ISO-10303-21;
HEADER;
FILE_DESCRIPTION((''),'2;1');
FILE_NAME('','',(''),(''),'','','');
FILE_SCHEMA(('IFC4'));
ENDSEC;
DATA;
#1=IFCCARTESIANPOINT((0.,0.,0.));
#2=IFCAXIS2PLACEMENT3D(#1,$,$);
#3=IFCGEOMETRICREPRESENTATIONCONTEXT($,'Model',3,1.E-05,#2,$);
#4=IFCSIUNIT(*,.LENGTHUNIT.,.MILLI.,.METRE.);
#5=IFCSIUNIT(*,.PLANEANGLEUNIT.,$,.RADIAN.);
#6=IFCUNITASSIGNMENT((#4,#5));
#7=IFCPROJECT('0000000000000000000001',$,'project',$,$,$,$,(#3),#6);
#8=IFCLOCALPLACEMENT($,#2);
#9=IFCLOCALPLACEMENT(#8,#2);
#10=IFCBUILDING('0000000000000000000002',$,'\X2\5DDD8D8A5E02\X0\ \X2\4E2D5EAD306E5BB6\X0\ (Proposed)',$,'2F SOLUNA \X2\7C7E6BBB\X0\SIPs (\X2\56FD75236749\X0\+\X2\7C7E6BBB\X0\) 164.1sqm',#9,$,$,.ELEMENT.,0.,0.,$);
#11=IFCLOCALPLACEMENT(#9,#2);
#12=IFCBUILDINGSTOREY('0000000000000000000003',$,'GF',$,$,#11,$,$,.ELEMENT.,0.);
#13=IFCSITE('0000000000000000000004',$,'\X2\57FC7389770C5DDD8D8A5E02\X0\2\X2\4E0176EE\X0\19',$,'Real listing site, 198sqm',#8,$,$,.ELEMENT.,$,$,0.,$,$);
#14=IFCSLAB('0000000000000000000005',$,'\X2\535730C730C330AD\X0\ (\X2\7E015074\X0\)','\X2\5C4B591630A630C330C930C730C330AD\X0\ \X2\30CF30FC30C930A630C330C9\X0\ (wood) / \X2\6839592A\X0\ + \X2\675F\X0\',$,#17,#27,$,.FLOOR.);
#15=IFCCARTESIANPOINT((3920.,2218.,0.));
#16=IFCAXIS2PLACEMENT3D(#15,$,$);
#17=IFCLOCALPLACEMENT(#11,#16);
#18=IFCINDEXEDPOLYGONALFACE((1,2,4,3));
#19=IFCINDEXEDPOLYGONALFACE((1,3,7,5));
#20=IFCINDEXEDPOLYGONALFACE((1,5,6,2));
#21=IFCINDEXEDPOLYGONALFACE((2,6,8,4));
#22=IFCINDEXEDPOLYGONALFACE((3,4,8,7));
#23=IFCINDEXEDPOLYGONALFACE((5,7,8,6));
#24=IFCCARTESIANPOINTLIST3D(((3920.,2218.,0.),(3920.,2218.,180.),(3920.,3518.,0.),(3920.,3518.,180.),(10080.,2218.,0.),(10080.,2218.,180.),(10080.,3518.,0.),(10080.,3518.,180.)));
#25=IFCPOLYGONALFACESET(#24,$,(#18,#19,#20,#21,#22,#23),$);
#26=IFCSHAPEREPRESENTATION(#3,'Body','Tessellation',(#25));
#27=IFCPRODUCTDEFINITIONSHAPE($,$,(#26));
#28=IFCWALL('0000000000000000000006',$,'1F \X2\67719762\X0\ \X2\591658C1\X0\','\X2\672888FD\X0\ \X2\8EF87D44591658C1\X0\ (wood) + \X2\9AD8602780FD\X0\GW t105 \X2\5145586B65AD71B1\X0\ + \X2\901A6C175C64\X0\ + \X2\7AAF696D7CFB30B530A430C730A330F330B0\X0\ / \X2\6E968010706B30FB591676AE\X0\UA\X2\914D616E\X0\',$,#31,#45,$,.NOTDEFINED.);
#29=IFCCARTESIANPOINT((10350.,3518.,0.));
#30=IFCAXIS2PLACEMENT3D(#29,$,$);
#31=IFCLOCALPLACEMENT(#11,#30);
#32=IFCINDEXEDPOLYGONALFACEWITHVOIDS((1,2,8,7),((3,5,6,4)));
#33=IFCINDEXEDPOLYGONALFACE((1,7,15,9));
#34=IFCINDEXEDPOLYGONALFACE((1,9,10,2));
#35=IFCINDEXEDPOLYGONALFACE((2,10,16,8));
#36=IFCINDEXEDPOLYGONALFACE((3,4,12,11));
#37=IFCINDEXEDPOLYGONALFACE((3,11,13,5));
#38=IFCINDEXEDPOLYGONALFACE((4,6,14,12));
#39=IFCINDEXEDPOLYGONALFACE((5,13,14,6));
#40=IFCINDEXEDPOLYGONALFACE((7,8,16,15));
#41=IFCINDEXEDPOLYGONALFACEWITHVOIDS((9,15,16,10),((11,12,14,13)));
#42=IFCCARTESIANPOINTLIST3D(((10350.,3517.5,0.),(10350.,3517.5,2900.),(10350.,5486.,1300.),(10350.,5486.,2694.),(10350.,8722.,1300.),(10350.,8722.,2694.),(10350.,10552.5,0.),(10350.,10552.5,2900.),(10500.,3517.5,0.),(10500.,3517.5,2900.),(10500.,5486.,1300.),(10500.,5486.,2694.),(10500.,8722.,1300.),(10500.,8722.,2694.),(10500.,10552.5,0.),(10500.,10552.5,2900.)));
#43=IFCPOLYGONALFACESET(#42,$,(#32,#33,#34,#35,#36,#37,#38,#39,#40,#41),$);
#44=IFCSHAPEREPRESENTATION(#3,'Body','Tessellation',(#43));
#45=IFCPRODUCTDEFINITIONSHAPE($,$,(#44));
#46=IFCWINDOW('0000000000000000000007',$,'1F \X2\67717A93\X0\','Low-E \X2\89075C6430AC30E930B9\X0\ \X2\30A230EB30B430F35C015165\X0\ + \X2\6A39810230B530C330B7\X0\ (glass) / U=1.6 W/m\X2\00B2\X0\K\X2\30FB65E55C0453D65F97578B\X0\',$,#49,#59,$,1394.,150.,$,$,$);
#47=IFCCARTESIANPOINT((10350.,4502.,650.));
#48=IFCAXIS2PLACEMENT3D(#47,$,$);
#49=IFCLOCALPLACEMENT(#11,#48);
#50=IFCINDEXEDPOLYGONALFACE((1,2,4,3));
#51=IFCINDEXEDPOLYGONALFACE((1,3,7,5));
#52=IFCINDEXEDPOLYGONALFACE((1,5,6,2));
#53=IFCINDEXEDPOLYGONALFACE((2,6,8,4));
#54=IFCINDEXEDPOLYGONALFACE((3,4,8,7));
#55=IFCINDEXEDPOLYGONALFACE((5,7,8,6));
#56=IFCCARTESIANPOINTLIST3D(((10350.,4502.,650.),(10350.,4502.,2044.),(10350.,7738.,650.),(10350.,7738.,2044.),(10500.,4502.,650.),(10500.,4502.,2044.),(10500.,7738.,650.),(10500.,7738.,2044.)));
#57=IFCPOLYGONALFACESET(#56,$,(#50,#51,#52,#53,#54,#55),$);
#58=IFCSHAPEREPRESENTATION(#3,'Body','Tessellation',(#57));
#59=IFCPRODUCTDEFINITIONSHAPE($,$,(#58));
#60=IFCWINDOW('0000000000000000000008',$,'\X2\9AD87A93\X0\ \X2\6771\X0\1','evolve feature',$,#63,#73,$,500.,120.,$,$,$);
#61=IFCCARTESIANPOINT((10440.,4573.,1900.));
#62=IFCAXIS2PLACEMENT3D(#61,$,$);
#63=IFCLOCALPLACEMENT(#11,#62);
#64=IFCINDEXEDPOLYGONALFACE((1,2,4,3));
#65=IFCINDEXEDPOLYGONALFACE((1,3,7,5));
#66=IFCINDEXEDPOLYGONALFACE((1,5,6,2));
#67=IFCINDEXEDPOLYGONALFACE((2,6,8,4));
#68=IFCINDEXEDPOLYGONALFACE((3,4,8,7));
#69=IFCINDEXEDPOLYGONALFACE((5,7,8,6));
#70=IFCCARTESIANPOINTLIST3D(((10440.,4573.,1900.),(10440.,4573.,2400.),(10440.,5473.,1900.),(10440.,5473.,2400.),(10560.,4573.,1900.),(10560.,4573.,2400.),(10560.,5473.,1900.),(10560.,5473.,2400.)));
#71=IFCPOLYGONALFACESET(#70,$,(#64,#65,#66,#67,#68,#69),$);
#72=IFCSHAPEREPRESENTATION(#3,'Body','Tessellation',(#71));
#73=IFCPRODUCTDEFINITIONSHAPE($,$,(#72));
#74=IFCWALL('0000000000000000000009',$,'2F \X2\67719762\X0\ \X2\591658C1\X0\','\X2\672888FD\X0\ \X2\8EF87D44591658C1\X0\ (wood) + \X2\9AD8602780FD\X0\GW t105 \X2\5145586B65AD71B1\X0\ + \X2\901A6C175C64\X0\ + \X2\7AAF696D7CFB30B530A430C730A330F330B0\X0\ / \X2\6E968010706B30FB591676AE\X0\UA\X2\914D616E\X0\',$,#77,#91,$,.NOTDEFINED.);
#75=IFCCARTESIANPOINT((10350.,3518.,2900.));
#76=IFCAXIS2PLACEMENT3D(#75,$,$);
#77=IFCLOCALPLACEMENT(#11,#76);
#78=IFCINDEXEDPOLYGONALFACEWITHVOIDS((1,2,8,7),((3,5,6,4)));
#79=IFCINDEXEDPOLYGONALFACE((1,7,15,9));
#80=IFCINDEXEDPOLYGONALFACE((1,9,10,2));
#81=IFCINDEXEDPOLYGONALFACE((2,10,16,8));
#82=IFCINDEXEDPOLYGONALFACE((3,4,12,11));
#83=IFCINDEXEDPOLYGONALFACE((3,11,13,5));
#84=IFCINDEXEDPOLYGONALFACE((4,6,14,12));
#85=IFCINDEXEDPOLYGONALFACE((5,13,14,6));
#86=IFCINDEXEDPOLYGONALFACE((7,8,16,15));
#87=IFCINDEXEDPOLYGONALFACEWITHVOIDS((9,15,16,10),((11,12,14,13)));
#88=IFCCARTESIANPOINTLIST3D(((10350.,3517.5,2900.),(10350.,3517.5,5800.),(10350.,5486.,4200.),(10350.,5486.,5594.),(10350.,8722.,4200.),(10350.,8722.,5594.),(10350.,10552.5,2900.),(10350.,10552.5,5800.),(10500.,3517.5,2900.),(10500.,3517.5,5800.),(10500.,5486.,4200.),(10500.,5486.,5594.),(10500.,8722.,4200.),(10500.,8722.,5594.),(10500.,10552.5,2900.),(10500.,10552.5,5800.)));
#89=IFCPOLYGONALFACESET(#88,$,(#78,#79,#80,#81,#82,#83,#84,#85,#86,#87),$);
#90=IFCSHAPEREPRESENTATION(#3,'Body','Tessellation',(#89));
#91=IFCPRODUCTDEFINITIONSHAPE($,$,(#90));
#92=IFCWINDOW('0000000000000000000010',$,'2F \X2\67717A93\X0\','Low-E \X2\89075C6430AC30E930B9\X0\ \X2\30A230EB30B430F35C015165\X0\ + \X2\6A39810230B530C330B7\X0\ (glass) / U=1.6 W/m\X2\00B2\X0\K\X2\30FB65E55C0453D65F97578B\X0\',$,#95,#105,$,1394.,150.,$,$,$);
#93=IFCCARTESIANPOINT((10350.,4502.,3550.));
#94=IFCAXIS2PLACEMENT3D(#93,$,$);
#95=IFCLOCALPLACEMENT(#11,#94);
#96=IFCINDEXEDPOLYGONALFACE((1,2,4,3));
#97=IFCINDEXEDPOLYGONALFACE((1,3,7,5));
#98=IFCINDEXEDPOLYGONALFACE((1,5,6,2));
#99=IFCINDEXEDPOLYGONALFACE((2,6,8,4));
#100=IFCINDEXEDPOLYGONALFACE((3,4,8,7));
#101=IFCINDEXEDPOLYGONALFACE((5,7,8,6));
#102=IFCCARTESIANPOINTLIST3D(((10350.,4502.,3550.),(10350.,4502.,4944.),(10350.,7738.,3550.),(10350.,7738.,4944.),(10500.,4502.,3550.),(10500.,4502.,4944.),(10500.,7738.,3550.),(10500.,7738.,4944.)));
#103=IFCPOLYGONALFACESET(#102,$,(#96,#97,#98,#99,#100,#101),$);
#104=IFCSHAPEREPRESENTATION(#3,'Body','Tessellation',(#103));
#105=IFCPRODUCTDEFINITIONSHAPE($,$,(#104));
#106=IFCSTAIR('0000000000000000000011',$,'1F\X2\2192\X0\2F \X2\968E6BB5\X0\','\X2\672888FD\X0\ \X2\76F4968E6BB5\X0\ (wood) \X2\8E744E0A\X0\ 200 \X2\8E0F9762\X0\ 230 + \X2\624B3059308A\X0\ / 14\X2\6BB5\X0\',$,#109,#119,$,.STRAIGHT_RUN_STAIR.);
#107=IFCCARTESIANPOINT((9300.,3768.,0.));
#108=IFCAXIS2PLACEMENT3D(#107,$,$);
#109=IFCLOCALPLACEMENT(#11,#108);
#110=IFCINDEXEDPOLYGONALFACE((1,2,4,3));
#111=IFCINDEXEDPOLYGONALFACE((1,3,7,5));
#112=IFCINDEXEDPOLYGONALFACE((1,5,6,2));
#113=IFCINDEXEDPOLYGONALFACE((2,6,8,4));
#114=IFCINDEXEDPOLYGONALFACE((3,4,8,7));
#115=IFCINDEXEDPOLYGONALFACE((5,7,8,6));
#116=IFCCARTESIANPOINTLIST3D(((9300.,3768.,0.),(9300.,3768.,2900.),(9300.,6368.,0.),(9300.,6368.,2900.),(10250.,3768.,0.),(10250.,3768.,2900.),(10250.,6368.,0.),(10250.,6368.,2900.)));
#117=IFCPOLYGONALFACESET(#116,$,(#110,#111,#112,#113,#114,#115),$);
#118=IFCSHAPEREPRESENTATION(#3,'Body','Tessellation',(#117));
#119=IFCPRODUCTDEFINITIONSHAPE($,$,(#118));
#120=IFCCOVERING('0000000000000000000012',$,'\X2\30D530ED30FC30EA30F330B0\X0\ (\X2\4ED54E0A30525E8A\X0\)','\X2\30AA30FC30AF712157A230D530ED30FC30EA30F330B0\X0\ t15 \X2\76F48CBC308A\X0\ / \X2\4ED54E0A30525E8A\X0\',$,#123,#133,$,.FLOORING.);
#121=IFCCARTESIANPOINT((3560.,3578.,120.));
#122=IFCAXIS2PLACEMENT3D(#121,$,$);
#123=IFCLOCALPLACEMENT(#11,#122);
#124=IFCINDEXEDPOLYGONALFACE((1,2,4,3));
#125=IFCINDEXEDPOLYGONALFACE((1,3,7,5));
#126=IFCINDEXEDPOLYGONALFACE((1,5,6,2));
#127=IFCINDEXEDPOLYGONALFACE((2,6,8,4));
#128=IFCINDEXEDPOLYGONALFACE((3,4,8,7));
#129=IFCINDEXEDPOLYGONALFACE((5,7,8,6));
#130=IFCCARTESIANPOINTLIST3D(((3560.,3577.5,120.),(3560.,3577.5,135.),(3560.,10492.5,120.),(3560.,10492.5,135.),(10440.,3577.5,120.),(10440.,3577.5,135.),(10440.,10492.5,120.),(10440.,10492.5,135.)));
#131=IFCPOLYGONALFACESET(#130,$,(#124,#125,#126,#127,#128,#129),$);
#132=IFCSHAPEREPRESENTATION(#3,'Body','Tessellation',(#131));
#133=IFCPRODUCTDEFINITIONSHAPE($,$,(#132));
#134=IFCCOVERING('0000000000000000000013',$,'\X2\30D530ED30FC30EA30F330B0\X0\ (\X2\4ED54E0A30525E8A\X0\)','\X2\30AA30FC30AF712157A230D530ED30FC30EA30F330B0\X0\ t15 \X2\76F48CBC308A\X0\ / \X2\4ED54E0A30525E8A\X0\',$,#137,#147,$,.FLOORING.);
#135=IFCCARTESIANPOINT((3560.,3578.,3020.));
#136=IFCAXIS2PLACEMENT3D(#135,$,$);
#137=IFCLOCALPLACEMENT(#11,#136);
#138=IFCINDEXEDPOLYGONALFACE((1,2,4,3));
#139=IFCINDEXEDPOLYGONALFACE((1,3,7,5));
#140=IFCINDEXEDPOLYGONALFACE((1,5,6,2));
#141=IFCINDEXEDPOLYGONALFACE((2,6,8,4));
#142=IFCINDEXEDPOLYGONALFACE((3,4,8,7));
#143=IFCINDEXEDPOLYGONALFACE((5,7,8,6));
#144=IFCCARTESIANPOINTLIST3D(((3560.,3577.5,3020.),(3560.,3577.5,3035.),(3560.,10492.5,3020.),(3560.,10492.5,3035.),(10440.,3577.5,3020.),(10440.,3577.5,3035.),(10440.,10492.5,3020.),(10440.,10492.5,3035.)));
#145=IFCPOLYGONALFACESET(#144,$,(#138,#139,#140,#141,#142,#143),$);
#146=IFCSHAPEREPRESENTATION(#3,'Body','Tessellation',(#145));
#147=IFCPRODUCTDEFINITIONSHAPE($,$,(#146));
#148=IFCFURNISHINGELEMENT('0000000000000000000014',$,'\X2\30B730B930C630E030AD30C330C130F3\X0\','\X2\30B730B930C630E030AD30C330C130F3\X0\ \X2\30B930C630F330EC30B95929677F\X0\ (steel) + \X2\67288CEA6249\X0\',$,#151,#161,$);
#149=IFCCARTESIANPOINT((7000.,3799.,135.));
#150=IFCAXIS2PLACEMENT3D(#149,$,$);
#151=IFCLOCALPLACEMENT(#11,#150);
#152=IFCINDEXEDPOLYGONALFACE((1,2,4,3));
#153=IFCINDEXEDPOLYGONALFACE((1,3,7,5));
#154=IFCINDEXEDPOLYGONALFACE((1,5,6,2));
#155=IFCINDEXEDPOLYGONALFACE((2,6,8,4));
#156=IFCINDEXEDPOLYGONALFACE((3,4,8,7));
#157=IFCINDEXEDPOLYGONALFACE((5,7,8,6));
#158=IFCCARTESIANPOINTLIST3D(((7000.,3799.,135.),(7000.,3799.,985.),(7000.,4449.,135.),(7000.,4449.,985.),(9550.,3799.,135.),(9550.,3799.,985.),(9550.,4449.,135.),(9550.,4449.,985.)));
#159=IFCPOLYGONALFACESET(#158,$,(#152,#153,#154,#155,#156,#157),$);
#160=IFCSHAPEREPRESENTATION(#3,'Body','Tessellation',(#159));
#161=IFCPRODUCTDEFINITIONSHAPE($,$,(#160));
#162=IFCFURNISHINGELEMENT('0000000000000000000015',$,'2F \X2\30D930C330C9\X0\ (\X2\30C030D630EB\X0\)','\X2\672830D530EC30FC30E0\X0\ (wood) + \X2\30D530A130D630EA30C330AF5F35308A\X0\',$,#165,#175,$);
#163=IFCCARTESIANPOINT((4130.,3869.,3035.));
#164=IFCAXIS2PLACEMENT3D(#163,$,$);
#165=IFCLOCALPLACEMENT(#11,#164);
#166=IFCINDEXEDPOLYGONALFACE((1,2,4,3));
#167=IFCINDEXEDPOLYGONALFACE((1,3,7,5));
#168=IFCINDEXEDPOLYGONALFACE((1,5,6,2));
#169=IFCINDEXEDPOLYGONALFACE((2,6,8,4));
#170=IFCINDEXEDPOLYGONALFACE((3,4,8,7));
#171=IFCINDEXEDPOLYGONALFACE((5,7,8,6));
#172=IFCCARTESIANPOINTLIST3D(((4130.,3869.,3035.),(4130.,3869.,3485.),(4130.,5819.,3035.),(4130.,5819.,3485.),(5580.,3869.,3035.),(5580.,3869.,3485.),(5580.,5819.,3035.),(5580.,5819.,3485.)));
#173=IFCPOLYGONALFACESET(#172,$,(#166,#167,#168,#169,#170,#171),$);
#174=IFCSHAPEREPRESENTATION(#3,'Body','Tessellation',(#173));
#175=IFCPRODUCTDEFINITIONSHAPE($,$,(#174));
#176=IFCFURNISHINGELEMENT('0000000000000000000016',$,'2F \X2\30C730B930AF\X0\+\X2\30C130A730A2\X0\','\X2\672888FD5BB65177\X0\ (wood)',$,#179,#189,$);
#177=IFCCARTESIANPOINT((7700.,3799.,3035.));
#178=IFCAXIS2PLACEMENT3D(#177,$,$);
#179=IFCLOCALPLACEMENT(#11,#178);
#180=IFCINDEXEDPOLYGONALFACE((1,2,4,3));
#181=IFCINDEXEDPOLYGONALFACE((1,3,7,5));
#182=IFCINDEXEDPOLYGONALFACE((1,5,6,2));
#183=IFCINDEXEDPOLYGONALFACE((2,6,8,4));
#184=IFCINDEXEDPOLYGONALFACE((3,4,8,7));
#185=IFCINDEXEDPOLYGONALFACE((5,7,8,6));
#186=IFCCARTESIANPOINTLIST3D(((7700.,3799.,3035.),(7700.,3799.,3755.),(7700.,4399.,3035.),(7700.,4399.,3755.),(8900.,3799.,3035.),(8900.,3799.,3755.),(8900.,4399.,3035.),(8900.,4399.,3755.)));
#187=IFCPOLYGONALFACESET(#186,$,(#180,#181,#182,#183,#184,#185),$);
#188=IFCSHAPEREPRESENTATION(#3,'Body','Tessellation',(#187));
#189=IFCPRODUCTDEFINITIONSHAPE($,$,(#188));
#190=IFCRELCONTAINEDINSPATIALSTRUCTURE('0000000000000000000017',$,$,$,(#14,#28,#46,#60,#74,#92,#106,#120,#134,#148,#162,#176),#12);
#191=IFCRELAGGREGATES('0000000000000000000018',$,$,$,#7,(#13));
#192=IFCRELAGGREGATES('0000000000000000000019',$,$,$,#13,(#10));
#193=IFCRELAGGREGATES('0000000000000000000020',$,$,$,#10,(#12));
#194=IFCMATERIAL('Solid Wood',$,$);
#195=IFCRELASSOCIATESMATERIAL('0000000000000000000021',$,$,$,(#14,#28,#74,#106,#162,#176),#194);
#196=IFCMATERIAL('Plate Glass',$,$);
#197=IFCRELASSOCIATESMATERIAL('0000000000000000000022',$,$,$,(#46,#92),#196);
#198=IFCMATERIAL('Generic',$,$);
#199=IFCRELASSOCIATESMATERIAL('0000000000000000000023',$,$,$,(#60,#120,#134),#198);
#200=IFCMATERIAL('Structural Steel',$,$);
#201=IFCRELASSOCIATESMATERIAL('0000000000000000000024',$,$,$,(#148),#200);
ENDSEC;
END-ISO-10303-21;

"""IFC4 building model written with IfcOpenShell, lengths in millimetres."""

from ifc_helpers import new_model, si_unit, frame, frame_2d, origin, place, context, project, spatial, rectangle, extrude, material, element, fill, save


model = new_model("IFC4")

# Units and contexts
model_context = context("Model", 3, precision=1e-05, world=origin())
ifc_project = project(units=[si_unit("LENGTHUNIT", "METRE", prefix="MILLI"), si_unit("PLANEANGLEUNIT", "RADIAN")], contexts=[model_context])

# Site, building, storey
site_placement = place(None, origin())
site = spatial("IfcSite", under=ifc_project, at=site_placement, Name="埼玉県川越市2丁目19", ObjectType="Real listing site, 198sqm", CompositionType="ELEMENT", RefElevation=0.0)
building_placement = place(site_placement, origin())
building = spatial("IfcBuilding", under=site, at=building_placement, Name="川越市 中庭の家 (Proposed)", ObjectType="2F SOLUNA 籾殻SIPs (国産杉+籾殻) 164.1sqm", CompositionType="ELEMENT", ElevationOfRefHeight=0.0, ElevationOfTerrain=0.0)
storey_placement = place(building_placement, origin())
storey = spatial("IfcBuildingStorey", under=building, at=storey_placement, Name="GF", CompositionType="ELEMENT", Elevation=0.0)

# Slab
ifc_material_1 = material(Name="Solid Wood")
slab_placement = place(storey_placement, frame((3920.0, 2218.0, 0.0)))
element("IfcSlab", 1, at=slab_placement, inside=storey, material=ifc_material_1, Name="南デッキ (縁側)", Description="屋外ウッドデッキ ハードウッド (wood) / 根太 + 束", PredefinedType="FLOOR", context=model_context, shape_type="SweptSolid", body=[
    extrude(rectangle(XDim=6160.0, YDim=1300.0, at=frame_2d((3080.0, 650.0))), frame((3920.0, 2218.0, 0.0)), (0.0, 0.0, 1.0), 180.0),
])

# Wall, openings, windows
wall_1_placement = place(storey_placement, frame((10350.0, 3518.0, 0.0)))
wall_1 = element("IfcWall", 2, at=wall_1_placement, inside=storey, material=ifc_material_1, Name="1F 東面 外壁", Description="木製 軸組外壁 (wood) + 高性能GW t105 充填断熱 + 通気層 + 窯業系サイディング / 準耐火・外皮UA配慮", PredefinedType="NOTDEFINED", context=model_context, shape_type="SweptSolid", body=[
    extrude(rectangle(XDim=150.0, YDim=7035.0, at=frame_2d((75.0, 3517.0))), frame((10350.0, 3518.0, 0.0)), (0.0, 0.0, 1.0), 2900.0),
])
opening_1_placement = place(storey_placement, frame((10350.0, 4502.0, 650.0)))
opening_1 = element("IfcOpeningElement", 3, at=opening_1_placement, cuts=wall_1, PredefinedType="NOTDEFINED", context=model_context, shape_type="SweptSolid", body=[
    extrude(rectangle(XDim=150.0, YDim=3236.0, at=frame_2d((75.0, 1618.0))), frame((10350.0, 4502.0, 650.0)), (0.0, 0.0, 1.0), 1394.0),
])
opening_2_placement = place(storey_placement, frame((10440.0, 4573.0, 1900.0)))
opening_2 = element("IfcOpeningElement", 4, at=opening_2_placement, cuts=wall_1, PredefinedType="NOTDEFINED", context=model_context, shape_type="SweptSolid", body=[
    extrude(rectangle(XDim=120.0, YDim=900.0, at=frame_2d((60.0, 450.0))), frame((10440.0, 4573.0, 1900.0)), (0.0, 0.0, 1.0), 500.0),
])
ifc_material_2 = material(Name="Plate Glass")
window_1_placement = place(storey_placement, frame((10350.0, 4502.0, 650.0)))
window_1 = element("IfcWindow", 5, at=window_1_placement, inside=storey, material=ifc_material_2, Name="1F 東窓", Description="Low-E 複層ガラス アルゴン封入 + 樹脂サッシ (glass) / U=1.6 W/m²K・日射取得型", OverallHeight=1394.0, OverallWidth=150.0, context=model_context, shape_type="SweptSolid", body=[
    extrude(rectangle(XDim=150.0, YDim=3236.0, at=frame_2d((75.0, 1618.0))), frame((10350.0, 4502.0, 650.0)), (0.0, 0.0, 1.0), 1394.0),
])
fill(opening_1, window_1)
ifc_material_3 = material(Name="Generic")
window_2_placement = place(storey_placement, frame((10440.0, 4573.0, 1900.0)))
window_2 = element("IfcWindow", 6, at=window_2_placement, inside=storey, material=ifc_material_3, Name="高窓 東1", Description="evolve feature", OverallHeight=500.0, OverallWidth=120.0, context=model_context, shape_type="SweptSolid", body=[
    extrude(rectangle(XDim=120.0, YDim=900.0, at=frame_2d((60.0, 450.0))), frame((10440.0, 4573.0, 1900.0)), (0.0, 0.0, 1.0), 500.0),
])
fill(opening_2, window_2)

# Wall, opening, window
wall_2_placement = place(storey_placement, frame((10350.0, 3518.0, 2900.0)))
wall_2 = element("IfcWall", 7, at=wall_2_placement, inside=storey, material=ifc_material_1, Name="2F 東面 外壁", Description="木製 軸組外壁 (wood) + 高性能GW t105 充填断熱 + 通気層 + 窯業系サイディング / 準耐火・外皮UA配慮", PredefinedType="NOTDEFINED", context=model_context, shape_type="SweptSolid", body=[
    extrude(rectangle(XDim=150.0, YDim=7035.0, at=frame_2d((75.0, 3517.0))), frame((10350.0, 3518.0, 2900.0)), (0.0, 0.0, 1.0), 2900.0),
])
opening_3_placement = place(storey_placement, frame((10350.0, 4502.0, 3550.0)))
opening_3 = element("IfcOpeningElement", 8, at=opening_3_placement, cuts=wall_2, PredefinedType="NOTDEFINED", context=model_context, shape_type="SweptSolid", body=[
    extrude(rectangle(XDim=150.0, YDim=3236.0, at=frame_2d((75.0, 1618.0))), frame((10350.0, 4502.0, 3550.0)), (0.0, 0.0, 1.0), 1394.0),
])
window_3_placement = place(storey_placement, frame((10350.0, 4502.0, 3550.0)))
window_3 = element("IfcWindow", 9, at=window_3_placement, inside=storey, material=ifc_material_2, Name="2F 東窓", Description="Low-E 複層ガラス アルゴン封入 + 樹脂サッシ (glass) / U=1.6 W/m²K・日射取得型", OverallHeight=1394.0, OverallWidth=150.0, context=model_context, shape_type="SweptSolid", body=[
    extrude(rectangle(XDim=150.0, YDim=3236.0, at=frame_2d((75.0, 1618.0))), frame((10350.0, 4502.0, 3550.0)), (0.0, 0.0, 1.0), 1394.0),
])
fill(opening_3, window_3)

# Stair
stair_placement = place(storey_placement, frame((9300.0, 3768.0, 0.0)))
element("IfcStair", 10, at=stair_placement, inside=storey, material=ifc_material_1, Name="1F→2F 階段", Description="木製 直階段 (wood) 蹴上 200 踏面 230 + 手すり / 14段", PredefinedType="STRAIGHT_RUN_STAIR", context=model_context, shape_type="SweptSolid", body=[
    extrude(rectangle(XDim=950.0, YDim=2600.0, at=frame_2d((475.0, 1300.0))), frame((9300.0, 3768.0, 0.0)), (0.0, 0.0, 1.0), 2900.0),
])

# Coverings
covering_1_placement = place(storey_placement, frame((3560.0, 3578.0, 120.0)))
element("IfcCovering", 11, at=covering_1_placement, inside=storey, material=ifc_material_3, Name="フローリング (仕上げ床)", Description="オーク無垢フローリング t15 直貼り / 仕上げ床", PredefinedType="FLOORING", context=model_context, shape_type="SweptSolid", body=[
    extrude(rectangle(XDim=6880.0, YDim=6915.0, at=frame_2d((3440.0, 3457.0))), frame((3560.0, 3578.0, 120.0)), (0.0, 0.0, 1.0), 15.0),
])
covering_2_placement = place(storey_placement, frame((3560.0, 3578.0, 3020.0)))
element("IfcCovering", 12, at=covering_2_placement, inside=storey, material=ifc_material_3, Name="フローリング (仕上げ床)", Description="オーク無垢フローリング t15 直貼り / 仕上げ床", PredefinedType="FLOORING", context=model_context, shape_type="SweptSolid", body=[
    extrude(rectangle(XDim=6880.0, YDim=6915.0, at=frame_2d((3440.0, 3457.0))), frame((3560.0, 3578.0, 3020.0)), (0.0, 0.0, 1.0), 15.0),
])

# Furnishing elements
ifc_material_4 = material(Name="Structural Steel")
furnishing_1_placement = place(storey_placement, frame((7000.0, 3799.0, 135.0)))
element("IfcFurnishingElement", 13, at=furnishing_1_placement, inside=storey, material=ifc_material_4, Name="システムキッチン", Description="システムキッチン ステンレス天板 (steel) + 木質扉", context=model_context, shape_type="SweptSolid", body=[
    extrude(rectangle(XDim=2550.0, YDim=650.0, at=frame_2d((1275.0, 325.0))), frame((7000.0, 3799.0, 135.0)), (0.0, 0.0, 1.0), 850.0),
])
furnishing_2_placement = place(storey_placement, frame((4130.0, 3869.0, 3035.0)))
element("IfcFurnishingElement", 14, at=furnishing_2_placement, inside=storey, material=ifc_material_1, Name="2F ベッド (ダブル)", Description="木フレーム (wood) + ファブリック張り", context=model_context, shape_type="SweptSolid", body=[
    extrude(rectangle(XDim=1450.0, YDim=1950.0, at=frame_2d((725.0, 975.0))), frame((4130.0, 3869.0, 3035.0)), (0.0, 0.0, 1.0), 450.0),
])
furnishing_3_placement = place(storey_placement, frame((7700.0, 3799.0, 3035.0)))
element("IfcFurnishingElement", 15, at=furnishing_3_placement, inside=storey, material=ifc_material_1, Name="2F デスク+チェア", Description="木製家具 (wood)", context=model_context, shape_type="SweptSolid", body=[
    extrude(rectangle(XDim=1200.0, YDim=600.0, at=frame_2d((600.0, 300.0))), frame((7700.0, 3799.0, 3035.0)), (0.0, 0.0, 1.0), 720.0),
])

save(model, "model.ifc")
